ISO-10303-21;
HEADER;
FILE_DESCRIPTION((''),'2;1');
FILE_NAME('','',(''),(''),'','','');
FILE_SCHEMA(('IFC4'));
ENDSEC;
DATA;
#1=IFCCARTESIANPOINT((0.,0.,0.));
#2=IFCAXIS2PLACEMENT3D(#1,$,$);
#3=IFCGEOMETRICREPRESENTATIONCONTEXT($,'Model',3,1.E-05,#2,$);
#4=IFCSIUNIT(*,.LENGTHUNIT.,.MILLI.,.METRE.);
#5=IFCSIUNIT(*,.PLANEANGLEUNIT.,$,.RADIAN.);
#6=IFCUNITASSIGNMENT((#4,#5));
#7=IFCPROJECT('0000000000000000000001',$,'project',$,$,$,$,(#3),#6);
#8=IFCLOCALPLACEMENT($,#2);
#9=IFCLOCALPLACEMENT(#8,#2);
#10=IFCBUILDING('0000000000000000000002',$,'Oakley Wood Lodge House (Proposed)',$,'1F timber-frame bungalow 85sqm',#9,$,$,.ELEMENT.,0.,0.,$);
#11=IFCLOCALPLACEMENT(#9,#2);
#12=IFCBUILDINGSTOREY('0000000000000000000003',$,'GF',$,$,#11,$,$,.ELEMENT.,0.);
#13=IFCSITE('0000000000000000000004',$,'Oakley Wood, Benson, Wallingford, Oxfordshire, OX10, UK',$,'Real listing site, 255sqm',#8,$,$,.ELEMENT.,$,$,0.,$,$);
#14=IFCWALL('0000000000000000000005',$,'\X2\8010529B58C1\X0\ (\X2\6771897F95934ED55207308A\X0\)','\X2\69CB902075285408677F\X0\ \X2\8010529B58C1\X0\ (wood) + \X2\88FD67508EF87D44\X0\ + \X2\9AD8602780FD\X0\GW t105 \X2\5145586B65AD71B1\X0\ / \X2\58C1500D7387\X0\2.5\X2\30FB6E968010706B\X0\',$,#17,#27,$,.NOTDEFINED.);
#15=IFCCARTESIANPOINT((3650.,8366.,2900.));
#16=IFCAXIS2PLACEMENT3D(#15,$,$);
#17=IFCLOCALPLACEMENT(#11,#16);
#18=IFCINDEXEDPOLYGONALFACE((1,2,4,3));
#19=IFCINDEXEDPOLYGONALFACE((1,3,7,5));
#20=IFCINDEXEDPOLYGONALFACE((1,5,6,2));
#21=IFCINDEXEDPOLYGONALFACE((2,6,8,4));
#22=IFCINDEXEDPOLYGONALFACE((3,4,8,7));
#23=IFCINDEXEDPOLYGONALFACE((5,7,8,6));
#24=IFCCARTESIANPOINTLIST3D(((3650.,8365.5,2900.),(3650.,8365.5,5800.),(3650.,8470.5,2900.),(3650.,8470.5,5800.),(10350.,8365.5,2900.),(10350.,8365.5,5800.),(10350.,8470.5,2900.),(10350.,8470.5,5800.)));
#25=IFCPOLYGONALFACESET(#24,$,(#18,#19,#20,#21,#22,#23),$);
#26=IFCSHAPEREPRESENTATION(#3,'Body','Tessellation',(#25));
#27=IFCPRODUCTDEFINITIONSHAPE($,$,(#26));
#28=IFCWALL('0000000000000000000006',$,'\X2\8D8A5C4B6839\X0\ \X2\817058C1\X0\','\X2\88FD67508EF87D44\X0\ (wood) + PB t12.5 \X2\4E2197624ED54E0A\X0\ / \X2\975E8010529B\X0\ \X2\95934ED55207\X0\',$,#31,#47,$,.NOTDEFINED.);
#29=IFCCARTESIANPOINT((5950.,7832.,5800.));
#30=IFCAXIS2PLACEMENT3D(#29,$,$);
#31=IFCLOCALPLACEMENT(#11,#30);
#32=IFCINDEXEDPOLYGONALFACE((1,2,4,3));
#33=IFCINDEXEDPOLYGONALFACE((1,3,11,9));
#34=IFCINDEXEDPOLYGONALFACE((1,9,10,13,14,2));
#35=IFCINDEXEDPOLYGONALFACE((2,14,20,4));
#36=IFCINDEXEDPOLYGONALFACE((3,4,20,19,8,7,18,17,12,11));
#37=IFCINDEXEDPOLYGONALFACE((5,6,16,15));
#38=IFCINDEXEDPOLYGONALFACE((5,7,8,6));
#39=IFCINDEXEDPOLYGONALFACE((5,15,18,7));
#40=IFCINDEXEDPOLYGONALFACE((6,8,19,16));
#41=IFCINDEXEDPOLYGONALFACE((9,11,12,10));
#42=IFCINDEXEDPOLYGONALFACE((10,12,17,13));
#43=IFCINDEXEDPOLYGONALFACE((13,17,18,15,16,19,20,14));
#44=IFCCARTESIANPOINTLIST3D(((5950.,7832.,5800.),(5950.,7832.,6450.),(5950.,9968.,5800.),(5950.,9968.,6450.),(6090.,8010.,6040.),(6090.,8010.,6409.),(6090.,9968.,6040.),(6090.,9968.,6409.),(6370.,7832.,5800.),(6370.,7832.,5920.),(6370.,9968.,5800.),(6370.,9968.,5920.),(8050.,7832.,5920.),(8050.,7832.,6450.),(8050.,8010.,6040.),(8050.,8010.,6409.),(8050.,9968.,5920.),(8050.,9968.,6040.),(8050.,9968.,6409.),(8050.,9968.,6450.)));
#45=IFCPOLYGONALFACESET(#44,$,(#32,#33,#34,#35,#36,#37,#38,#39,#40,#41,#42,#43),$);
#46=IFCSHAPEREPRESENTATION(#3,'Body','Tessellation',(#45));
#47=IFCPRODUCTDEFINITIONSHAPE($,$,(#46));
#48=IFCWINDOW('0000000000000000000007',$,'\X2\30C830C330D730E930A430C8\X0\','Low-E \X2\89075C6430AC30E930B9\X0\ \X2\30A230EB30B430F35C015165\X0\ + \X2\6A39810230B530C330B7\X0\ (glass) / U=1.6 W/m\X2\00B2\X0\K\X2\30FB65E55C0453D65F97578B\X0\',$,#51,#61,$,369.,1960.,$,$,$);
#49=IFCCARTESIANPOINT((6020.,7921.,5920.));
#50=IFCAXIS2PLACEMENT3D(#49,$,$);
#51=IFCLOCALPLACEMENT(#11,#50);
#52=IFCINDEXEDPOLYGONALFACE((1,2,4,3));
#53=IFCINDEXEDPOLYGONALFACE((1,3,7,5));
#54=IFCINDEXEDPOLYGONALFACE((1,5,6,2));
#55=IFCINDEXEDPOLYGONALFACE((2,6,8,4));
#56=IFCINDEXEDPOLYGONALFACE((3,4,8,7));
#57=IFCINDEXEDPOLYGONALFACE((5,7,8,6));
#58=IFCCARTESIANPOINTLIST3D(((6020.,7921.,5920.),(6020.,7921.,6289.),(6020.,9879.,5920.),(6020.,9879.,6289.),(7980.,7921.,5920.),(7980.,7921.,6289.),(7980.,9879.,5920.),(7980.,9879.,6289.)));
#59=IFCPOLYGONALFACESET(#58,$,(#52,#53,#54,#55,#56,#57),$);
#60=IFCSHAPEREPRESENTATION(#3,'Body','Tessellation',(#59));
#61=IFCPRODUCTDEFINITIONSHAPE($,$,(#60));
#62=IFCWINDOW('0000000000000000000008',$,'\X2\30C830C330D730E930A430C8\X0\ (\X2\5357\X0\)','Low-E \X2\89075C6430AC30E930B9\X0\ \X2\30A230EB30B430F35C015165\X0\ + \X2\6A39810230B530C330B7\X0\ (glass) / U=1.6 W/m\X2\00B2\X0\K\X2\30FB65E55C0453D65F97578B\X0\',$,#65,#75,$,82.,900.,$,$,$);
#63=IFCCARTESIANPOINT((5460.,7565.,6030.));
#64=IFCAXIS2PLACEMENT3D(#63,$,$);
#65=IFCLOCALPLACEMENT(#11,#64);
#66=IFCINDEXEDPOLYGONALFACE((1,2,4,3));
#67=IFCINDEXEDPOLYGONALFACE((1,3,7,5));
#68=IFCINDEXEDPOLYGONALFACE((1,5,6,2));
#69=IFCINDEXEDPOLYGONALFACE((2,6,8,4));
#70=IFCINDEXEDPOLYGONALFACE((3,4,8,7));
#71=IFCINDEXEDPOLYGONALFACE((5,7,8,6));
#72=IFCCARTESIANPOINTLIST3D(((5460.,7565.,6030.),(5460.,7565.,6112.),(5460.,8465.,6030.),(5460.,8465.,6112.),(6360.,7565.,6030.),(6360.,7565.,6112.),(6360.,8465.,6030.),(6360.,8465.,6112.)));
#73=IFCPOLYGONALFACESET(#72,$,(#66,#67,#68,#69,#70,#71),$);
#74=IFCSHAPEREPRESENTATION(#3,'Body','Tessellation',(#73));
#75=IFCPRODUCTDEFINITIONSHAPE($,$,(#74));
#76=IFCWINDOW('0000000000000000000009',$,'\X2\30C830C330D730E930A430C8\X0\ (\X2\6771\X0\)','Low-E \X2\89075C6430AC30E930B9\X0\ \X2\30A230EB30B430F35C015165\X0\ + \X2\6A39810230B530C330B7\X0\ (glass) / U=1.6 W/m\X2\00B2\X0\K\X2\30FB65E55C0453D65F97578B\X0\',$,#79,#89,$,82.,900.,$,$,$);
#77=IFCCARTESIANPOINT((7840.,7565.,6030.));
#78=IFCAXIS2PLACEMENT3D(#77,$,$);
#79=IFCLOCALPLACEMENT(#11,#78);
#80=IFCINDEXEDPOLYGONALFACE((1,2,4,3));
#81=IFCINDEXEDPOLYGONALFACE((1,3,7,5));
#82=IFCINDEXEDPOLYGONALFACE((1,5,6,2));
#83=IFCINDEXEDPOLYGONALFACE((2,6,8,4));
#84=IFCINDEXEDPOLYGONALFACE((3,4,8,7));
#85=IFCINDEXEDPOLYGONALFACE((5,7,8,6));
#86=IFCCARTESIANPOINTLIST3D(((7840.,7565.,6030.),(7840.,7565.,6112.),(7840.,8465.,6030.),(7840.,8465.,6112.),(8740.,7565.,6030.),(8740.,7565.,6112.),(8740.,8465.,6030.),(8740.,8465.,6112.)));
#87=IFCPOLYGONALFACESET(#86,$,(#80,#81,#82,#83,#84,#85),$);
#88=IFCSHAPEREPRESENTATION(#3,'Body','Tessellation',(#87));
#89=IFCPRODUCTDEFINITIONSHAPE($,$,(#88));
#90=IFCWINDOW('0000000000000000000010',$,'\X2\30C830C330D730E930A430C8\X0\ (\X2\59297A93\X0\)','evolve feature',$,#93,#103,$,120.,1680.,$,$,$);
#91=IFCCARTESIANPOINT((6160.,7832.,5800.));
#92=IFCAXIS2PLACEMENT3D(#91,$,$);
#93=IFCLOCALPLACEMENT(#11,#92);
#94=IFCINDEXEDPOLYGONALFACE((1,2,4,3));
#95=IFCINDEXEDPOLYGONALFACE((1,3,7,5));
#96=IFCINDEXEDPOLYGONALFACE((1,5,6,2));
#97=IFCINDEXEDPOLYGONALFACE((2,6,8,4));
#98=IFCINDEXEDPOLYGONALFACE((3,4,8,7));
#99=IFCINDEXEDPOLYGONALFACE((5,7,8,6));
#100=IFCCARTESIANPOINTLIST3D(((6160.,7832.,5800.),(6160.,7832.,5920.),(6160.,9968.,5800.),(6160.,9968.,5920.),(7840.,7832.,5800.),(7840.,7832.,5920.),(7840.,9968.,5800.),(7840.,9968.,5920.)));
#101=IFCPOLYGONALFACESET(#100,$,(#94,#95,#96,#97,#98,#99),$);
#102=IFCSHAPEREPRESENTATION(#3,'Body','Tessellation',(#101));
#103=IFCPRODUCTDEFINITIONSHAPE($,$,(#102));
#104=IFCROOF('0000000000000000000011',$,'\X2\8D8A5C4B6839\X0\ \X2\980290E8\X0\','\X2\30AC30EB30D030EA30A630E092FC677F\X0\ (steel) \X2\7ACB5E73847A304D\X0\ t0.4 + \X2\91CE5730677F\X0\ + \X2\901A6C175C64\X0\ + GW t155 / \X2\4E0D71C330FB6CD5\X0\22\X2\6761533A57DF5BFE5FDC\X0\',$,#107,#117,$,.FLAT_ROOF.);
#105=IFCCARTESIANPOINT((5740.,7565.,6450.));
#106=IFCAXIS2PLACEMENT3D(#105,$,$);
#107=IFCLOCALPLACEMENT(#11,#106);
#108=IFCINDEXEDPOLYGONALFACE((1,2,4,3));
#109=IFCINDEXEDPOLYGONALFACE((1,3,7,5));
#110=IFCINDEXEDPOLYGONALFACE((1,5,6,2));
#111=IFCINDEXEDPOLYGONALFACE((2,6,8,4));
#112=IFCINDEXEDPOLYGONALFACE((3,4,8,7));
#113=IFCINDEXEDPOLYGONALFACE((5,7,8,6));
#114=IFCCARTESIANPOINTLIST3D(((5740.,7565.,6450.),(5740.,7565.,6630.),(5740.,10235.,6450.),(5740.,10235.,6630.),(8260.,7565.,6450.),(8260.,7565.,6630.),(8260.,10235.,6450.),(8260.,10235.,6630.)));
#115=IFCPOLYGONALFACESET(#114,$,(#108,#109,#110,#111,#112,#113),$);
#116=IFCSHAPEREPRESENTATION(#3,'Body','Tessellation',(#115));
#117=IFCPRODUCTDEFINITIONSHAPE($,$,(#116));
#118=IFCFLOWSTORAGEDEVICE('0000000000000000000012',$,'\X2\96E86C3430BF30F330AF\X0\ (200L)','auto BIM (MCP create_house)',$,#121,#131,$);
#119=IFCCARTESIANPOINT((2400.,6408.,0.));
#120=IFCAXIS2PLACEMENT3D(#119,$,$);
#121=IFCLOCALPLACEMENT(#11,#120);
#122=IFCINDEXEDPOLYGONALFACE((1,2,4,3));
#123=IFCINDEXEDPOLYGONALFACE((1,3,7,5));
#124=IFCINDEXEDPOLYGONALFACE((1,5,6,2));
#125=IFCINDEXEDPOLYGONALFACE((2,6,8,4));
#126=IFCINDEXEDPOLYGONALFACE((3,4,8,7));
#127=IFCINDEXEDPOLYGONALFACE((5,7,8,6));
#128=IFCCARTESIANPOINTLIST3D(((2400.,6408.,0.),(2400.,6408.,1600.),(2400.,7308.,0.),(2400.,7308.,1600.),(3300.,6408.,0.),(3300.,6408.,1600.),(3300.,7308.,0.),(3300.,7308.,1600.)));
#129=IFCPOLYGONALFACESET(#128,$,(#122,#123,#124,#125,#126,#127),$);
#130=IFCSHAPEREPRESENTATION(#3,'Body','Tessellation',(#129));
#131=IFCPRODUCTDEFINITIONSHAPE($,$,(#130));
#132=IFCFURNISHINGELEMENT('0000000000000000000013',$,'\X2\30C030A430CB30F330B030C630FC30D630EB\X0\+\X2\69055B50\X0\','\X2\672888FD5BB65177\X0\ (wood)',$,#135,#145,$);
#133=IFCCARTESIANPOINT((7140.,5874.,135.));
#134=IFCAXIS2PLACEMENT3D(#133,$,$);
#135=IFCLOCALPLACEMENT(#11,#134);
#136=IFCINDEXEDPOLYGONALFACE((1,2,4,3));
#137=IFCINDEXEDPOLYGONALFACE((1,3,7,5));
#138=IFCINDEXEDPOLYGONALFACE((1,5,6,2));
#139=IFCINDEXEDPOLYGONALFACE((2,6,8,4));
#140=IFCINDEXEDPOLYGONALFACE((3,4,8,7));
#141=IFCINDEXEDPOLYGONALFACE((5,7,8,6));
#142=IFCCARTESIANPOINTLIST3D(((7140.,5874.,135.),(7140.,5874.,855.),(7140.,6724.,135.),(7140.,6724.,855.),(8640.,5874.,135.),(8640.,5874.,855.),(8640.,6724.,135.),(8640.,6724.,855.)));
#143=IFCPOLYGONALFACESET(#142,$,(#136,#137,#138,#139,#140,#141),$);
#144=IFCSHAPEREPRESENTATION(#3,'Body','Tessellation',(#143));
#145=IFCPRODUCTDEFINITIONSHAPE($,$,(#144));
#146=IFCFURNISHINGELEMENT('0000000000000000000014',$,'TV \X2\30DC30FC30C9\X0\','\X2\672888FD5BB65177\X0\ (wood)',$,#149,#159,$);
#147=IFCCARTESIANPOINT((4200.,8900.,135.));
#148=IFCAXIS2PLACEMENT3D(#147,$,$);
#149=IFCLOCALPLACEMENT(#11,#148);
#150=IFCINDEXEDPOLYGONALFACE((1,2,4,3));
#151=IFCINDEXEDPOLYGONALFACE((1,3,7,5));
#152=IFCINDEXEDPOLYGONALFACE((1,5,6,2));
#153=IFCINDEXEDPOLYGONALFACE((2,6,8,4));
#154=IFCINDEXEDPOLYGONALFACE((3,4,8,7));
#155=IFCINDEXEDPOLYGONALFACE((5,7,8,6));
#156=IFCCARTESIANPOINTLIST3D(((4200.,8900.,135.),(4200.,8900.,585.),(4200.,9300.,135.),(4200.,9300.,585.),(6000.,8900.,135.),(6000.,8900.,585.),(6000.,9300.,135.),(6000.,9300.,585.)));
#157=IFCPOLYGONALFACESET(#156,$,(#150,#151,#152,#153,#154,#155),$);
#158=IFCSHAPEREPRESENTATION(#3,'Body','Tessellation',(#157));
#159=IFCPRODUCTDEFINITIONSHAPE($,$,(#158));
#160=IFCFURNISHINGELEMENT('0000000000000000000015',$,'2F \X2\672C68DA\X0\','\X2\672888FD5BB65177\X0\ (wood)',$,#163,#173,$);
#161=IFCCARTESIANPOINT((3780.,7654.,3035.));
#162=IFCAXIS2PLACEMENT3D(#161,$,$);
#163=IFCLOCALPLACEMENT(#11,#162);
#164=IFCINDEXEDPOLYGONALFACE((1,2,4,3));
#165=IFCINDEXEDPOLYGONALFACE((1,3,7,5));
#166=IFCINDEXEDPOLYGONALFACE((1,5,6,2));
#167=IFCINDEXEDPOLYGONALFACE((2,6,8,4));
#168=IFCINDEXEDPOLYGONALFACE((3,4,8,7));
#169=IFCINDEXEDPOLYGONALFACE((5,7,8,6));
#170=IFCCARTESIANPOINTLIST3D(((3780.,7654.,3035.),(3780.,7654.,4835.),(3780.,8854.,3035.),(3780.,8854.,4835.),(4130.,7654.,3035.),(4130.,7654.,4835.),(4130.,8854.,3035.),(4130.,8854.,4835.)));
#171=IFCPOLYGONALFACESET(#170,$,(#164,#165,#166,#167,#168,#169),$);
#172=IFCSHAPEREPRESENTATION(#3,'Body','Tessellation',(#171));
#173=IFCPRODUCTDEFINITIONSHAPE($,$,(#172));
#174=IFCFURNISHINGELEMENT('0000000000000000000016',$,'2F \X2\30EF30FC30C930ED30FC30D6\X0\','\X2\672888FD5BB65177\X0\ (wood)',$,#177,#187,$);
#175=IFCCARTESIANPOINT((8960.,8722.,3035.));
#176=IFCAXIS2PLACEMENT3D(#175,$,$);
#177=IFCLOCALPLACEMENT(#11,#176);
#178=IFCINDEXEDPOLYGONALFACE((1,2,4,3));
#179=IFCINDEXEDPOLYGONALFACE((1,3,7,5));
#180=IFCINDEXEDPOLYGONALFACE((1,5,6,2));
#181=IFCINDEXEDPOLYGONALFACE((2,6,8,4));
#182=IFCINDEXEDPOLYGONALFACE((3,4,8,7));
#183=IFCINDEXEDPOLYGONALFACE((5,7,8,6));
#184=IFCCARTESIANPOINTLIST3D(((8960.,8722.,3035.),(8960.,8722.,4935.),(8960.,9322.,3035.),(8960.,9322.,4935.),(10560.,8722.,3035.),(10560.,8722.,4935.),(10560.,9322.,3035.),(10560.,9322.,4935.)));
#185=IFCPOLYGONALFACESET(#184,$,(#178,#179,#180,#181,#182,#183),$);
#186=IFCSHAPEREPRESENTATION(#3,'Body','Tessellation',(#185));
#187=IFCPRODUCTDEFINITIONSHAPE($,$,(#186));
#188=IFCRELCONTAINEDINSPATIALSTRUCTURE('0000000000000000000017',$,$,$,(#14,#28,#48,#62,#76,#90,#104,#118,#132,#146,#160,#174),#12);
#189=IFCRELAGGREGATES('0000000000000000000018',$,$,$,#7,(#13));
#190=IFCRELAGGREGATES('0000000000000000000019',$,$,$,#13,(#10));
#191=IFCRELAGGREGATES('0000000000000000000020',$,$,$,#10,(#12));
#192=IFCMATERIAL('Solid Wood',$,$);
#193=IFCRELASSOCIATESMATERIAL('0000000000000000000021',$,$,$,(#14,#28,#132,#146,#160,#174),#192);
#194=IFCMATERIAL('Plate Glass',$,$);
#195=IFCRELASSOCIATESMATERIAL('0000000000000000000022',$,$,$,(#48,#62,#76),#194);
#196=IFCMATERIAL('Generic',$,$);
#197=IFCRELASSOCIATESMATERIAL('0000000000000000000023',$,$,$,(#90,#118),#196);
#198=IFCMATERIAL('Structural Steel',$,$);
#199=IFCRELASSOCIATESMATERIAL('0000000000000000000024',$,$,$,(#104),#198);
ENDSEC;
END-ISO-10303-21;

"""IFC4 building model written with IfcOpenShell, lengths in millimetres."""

from ifc_helpers import new_model, si_unit, frame, frame_2d, origin, place, context, project, spatial, rectangle, extrude, material, element, fill, save


model = new_model("IFC4")

# Units and contexts
model_context = context("Model", 3, precision=1e-05, world=origin())
ifc_project = project(units=[si_unit("LENGTHUNIT", "METRE", prefix="MILLI"), si_unit("PLANEANGLEUNIT", "RADIAN")], contexts=[model_context])

# Site, building, storey
site_placement = place(None, origin())
site = spatial("IfcSite", under=ifc_project, at=site_placement, Name="Oakley Wood, Benson, Wallingford, Oxfordshire, OX10, UK", ObjectType="Real listing site, 255sqm", CompositionType="ELEMENT", RefElevation=0.0)
building_placement = place(site_placement, origin())
building = spatial("IfcBuilding", under=site, at=building_placement, Name="Oakley Wood Lodge House (Proposed)", ObjectType="1F timber-frame bungalow 85sqm", CompositionType="ELEMENT", ElevationOfRefHeight=0.0, ElevationOfTerrain=0.0)
storey_placement = place(building_placement, origin())
storey = spatial("IfcBuildingStorey", under=building, at=storey_placement, Name="GF", CompositionType="ELEMENT", Elevation=0.0)

# Wall
ifc_material_1 = material(Name="Solid Wood")
wall_1_placement = place(storey_placement, frame((3650.0, 8366.0, 2900.0)))
element("IfcWall", 1, at=wall_1_placement, inside=storey, material=ifc_material_1, Name="耐力壁 (東西間仕切り)", Description="構造用合板 耐力壁 (wood) + 製材軸組 + 高性能GW t105 充填断熱 / 壁倍率2.5・準耐火", PredefinedType="NOTDEFINED", context=model_context, shape_type="SweptSolid", body=[
    extrude(rectangle(XDim=6700.0, YDim=105.0, at=frame_2d((3350.0, 52.0))), frame((3650.0, 8366.0, 2900.0)), (0.0, 0.0, 1.0), 2900.0),
])

# Wall, openings, windows
wall_2_placement = place(storey_placement, frame((5950.0, 7832.0, 5800.0)))
wall_2 = element("IfcWall", 2, at=wall_2_placement, inside=storey, material=ifc_material_1, Name="越屋根 腰壁", Description="製材軸組 (wood) + PB t12.5 両面仕上 / 非耐力 間仕切", PredefinedType="NOTDEFINED", context=model_context, shape_type="SweptSolid", body=[
    extrude(rectangle(XDim=2100.0, YDim=2136.0, at=frame_2d((1050.0, 1068.0))), frame((5950.0, 7832.0, 5800.0)), (0.0, 0.0, 1.0), 650.0),
])
opening_1_placement = place(storey_placement, frame((6020.0, 7921.0, 5920.0)))
opening_1 = element("IfcOpeningElement", 3, at=opening_1_placement, cuts=wall_2, PredefinedType="NOTDEFINED", context=model_context, shape_type="SweptSolid", body=[
    extrude(rectangle(XDim=1960.0, YDim=1958.0, at=frame_2d((980.0, 979.0))), frame((6020.0, 7921.0, 5920.0)), (0.0, 0.0, 1.0), 369.0),
])
opening_2_placement = place(storey_placement, frame((5460.0, 7565.0, 6030.0)))
opening_2 = element("IfcOpeningElement", 4, at=opening_2_placement, cuts=wall_2, PredefinedType="NOTDEFINED", context=model_context, shape_type="SweptSolid", body=[
    extrude(rectangle(XDim=900.0, YDim=900.0, at=frame_2d((450.0, 450.0))), frame((5460.0, 7565.0, 6030.0)), (0.0, 0.0, 1.0), 82.0),
])
opening_3_placement = place(storey_placement, frame((7840.0, 7565.0, 6030.0)))
opening_3 = element("IfcOpeningElement", 5, at=opening_3_placement, cuts=wall_2, PredefinedType="NOTDEFINED", context=model_context, shape_type="SweptSolid", body=[
    extrude(rectangle(XDim=900.0, YDim=900.0, at=frame_2d((450.0, 450.0))), frame((7840.0, 7565.0, 6030.0)), (0.0, 0.0, 1.0), 82.0),
])
opening_4_placement = place(storey_placement, frame((6160.0, 7832.0, 5800.0)))
opening_4 = element("IfcOpeningElement", 6, at=opening_4_placement, cuts=wall_2, PredefinedType="NOTDEFINED", context=model_context, shape_type="SweptSolid", body=[
    extrude(rectangle(XDim=1680.0, YDim=2136.0, at=frame_2d((840.0, 1068.0))), frame((6160.0, 7832.0, 5800.0)), (0.0, 0.0, 1.0), 120.0),
])
ifc_material_2 = material(Name="Plate Glass")
window_1_placement = place(storey_placement, frame((6020.0, 7921.0, 5920.0)))
window_1 = element("IfcWindow", 7, at=window_1_placement, inside=storey, material=ifc_material_2, Name="トップライト", Description="Low-E 複層ガラス アルゴン封入 + 樹脂サッシ (glass) / U=1.6 W/m²K・日射取得型", OverallHeight=369.0, OverallWidth=1960.0, context=model_context, shape_type="SweptSolid", body=[
    extrude(rectangle(XDim=1960.0, YDim=1958.0, at=frame_2d((980.0, 979.0))), frame((6020.0, 7921.0, 5920.0)), (0.0, 0.0, 1.0), 369.0),
])
fill(opening_1, window_1)
window_2_placement = place(storey_placement, frame((5460.0, 7565.0, 6030.0)))
window_2 = element("IfcWindow", 8, at=window_2_placement, inside=storey, material=ifc_material_2, Name="トップライト (南)", Description="Low-E 複層ガラス アルゴン封入 + 樹脂サッシ (glass) / U=1.6 W/m²K・日射取得型", OverallHeight=82.0, OverallWidth=900.0, context=model_context, shape_type="SweptSolid", body=[
    extrude(rectangle(XDim=900.0, YDim=900.0, at=frame_2d((450.0, 450.0))), frame((5460.0, 7565.0, 6030.0)), (0.0, 0.0, 1.0), 82.0),
])
fill(opening_2, window_2)
window_3_placement = place(storey_placement, frame((7840.0, 7565.0, 6030.0)))
window_3 = element("IfcWindow", 9, at=window_3_placement, inside=storey, material=ifc_material_2, Name="トップライト (東)", Description="Low-E 複層ガラス アルゴン封入 + 樹脂サッシ (glass) / U=1.6 W/m²K・日射取得型", OverallHeight=82.0, OverallWidth=900.0, context=model_context, shape_type="SweptSolid", body=[
    extrude(rectangle(XDim=900.0, YDim=900.0, at=frame_2d((450.0, 450.0))), frame((7840.0, 7565.0, 6030.0)), (0.0, 0.0, 1.0), 82.0),
])
fill(opening_3, window_3)
ifc_material_3 = material(Name="Generic")
window_4_placement = place(storey_placement, frame((6160.0, 7832.0, 5800.0)))
window_4 = element("IfcWindow", 10, at=window_4_placement, inside=storey, material=ifc_material_3, Name="トップライト (天窓)", Description="evolve feature", OverallHeight=120.0, OverallWidth=1680.0, context=model_context, shape_type="SweptSolid", body=[
    extrude(rectangle(XDim=1680.0, YDim=2136.0, at=frame_2d((840.0, 1068.0))), frame((6160.0, 7832.0, 5800.0)), (0.0, 0.0, 1.0), 120.0),
])
fill(opening_4, window_4)

# Roof
ifc_material_4 = material(Name="Structural Steel")
roof_placement = place(storey_placement, frame((5740.0, 7565.0, 6450.0)))
element("IfcRoof", 11, at=roof_placement, inside=storey, material=ifc_material_4, Name="越屋根 頂部", Description="ガルバリウム鋼板 (steel) 立平葺き t0.4 + 野地板 + 通気層 + GW t155 / 不燃・法22条区域対応", PredefinedType="FLAT_ROOF", context=model_context, shape_type="SweptSolid", body=[
    extrude(rectangle(XDim=2520.0, YDim=2670.0, at=frame_2d((1260.0, 1335.0))), frame((5740.0, 7565.0, 6450.0)), (0.0, 0.0, 1.0), 180.0),
])

# Flow storage device
flow_storage_device_placement = place(storey_placement, frame((2400.0, 6408.0, 0.0)))
element("IfcFlowStorageDevice", 12, at=flow_storage_device_placement, inside=storey, material=ifc_material_3, Name="雨水タンク (200L)", Description="auto BIM (MCP create_house)", context=model_context, shape_type="SweptSolid", body=[
    extrude(rectangle(XDim=900.0, YDim=900.0, at=frame_2d((450.0, 450.0))), frame((2400.0, 6408.0, 0.0)), (0.0, 0.0, 1.0), 1600.0),
])

# Furnishing elements
furnishing_1_placement = place(storey_placement, frame((7140.0, 5874.0, 135.0)))
element("IfcFurnishingElement", 13, at=furnishing_1_placement, inside=storey, material=ifc_material_1, Name="ダイニングテーブル+椅子", Description="木製家具 (wood)", context=model_context, shape_type="SweptSolid", body=[
    extrude(rectangle(XDim=1500.0, YDim=850.0, at=frame_2d((750.0, 425.0))), frame((7140.0, 5874.0, 135.0)), (0.0, 0.0, 1.0), 720.0),
])
furnishing_2_placement = place(storey_placement, frame((4200.0, 8900.0, 135.0)))
element("IfcFurnishingElement", 14, at=furnishing_2_placement, inside=storey, material=ifc_material_1, Name="TV ボード", Description="木製家具 (wood)", context=model_context, shape_type="SweptSolid", body=[
    extrude(rectangle(XDim=1800.0, YDim=400.0, at=frame_2d((900.0, 200.0))), frame((4200.0, 8900.0, 135.0)), (0.0, 0.0, 1.0), 450.0),
])
furnishing_3_placement = place(storey_placement, frame((3780.0, 7654.0, 3035.0)))
element("IfcFurnishingElement", 15, at=furnishing_3_placement, inside=storey, material=ifc_material_1, Name="2F 本棚", Description="木製家具 (wood)", context=model_context, shape_type="SweptSolid", body=[
    extrude(rectangle(XDim=350.0, YDim=1200.0, at=frame_2d((175.0, 600.0))), frame((3780.0, 7654.0, 3035.0)), (0.0, 0.0, 1.0), 1800.0),
])
furnishing_4_placement = place(storey_placement, frame((8960.0, 8722.0, 3035.0)))
element("IfcFurnishingElement", 16, at=furnishing_4_placement, inside=storey, material=ifc_material_1, Name="2F ワードローブ", Description="木製家具 (wood)", context=model_context, shape_type="SweptSolid", body=[
    extrude(rectangle(XDim=1600.0, YDim=600.0, at=frame_2d((800.0, 300.0))), frame((8960.0, 8722.0, 3035.0)), (0.0, 0.0, 1.0), 1900.0),
])

save(model, "model.ifc")
